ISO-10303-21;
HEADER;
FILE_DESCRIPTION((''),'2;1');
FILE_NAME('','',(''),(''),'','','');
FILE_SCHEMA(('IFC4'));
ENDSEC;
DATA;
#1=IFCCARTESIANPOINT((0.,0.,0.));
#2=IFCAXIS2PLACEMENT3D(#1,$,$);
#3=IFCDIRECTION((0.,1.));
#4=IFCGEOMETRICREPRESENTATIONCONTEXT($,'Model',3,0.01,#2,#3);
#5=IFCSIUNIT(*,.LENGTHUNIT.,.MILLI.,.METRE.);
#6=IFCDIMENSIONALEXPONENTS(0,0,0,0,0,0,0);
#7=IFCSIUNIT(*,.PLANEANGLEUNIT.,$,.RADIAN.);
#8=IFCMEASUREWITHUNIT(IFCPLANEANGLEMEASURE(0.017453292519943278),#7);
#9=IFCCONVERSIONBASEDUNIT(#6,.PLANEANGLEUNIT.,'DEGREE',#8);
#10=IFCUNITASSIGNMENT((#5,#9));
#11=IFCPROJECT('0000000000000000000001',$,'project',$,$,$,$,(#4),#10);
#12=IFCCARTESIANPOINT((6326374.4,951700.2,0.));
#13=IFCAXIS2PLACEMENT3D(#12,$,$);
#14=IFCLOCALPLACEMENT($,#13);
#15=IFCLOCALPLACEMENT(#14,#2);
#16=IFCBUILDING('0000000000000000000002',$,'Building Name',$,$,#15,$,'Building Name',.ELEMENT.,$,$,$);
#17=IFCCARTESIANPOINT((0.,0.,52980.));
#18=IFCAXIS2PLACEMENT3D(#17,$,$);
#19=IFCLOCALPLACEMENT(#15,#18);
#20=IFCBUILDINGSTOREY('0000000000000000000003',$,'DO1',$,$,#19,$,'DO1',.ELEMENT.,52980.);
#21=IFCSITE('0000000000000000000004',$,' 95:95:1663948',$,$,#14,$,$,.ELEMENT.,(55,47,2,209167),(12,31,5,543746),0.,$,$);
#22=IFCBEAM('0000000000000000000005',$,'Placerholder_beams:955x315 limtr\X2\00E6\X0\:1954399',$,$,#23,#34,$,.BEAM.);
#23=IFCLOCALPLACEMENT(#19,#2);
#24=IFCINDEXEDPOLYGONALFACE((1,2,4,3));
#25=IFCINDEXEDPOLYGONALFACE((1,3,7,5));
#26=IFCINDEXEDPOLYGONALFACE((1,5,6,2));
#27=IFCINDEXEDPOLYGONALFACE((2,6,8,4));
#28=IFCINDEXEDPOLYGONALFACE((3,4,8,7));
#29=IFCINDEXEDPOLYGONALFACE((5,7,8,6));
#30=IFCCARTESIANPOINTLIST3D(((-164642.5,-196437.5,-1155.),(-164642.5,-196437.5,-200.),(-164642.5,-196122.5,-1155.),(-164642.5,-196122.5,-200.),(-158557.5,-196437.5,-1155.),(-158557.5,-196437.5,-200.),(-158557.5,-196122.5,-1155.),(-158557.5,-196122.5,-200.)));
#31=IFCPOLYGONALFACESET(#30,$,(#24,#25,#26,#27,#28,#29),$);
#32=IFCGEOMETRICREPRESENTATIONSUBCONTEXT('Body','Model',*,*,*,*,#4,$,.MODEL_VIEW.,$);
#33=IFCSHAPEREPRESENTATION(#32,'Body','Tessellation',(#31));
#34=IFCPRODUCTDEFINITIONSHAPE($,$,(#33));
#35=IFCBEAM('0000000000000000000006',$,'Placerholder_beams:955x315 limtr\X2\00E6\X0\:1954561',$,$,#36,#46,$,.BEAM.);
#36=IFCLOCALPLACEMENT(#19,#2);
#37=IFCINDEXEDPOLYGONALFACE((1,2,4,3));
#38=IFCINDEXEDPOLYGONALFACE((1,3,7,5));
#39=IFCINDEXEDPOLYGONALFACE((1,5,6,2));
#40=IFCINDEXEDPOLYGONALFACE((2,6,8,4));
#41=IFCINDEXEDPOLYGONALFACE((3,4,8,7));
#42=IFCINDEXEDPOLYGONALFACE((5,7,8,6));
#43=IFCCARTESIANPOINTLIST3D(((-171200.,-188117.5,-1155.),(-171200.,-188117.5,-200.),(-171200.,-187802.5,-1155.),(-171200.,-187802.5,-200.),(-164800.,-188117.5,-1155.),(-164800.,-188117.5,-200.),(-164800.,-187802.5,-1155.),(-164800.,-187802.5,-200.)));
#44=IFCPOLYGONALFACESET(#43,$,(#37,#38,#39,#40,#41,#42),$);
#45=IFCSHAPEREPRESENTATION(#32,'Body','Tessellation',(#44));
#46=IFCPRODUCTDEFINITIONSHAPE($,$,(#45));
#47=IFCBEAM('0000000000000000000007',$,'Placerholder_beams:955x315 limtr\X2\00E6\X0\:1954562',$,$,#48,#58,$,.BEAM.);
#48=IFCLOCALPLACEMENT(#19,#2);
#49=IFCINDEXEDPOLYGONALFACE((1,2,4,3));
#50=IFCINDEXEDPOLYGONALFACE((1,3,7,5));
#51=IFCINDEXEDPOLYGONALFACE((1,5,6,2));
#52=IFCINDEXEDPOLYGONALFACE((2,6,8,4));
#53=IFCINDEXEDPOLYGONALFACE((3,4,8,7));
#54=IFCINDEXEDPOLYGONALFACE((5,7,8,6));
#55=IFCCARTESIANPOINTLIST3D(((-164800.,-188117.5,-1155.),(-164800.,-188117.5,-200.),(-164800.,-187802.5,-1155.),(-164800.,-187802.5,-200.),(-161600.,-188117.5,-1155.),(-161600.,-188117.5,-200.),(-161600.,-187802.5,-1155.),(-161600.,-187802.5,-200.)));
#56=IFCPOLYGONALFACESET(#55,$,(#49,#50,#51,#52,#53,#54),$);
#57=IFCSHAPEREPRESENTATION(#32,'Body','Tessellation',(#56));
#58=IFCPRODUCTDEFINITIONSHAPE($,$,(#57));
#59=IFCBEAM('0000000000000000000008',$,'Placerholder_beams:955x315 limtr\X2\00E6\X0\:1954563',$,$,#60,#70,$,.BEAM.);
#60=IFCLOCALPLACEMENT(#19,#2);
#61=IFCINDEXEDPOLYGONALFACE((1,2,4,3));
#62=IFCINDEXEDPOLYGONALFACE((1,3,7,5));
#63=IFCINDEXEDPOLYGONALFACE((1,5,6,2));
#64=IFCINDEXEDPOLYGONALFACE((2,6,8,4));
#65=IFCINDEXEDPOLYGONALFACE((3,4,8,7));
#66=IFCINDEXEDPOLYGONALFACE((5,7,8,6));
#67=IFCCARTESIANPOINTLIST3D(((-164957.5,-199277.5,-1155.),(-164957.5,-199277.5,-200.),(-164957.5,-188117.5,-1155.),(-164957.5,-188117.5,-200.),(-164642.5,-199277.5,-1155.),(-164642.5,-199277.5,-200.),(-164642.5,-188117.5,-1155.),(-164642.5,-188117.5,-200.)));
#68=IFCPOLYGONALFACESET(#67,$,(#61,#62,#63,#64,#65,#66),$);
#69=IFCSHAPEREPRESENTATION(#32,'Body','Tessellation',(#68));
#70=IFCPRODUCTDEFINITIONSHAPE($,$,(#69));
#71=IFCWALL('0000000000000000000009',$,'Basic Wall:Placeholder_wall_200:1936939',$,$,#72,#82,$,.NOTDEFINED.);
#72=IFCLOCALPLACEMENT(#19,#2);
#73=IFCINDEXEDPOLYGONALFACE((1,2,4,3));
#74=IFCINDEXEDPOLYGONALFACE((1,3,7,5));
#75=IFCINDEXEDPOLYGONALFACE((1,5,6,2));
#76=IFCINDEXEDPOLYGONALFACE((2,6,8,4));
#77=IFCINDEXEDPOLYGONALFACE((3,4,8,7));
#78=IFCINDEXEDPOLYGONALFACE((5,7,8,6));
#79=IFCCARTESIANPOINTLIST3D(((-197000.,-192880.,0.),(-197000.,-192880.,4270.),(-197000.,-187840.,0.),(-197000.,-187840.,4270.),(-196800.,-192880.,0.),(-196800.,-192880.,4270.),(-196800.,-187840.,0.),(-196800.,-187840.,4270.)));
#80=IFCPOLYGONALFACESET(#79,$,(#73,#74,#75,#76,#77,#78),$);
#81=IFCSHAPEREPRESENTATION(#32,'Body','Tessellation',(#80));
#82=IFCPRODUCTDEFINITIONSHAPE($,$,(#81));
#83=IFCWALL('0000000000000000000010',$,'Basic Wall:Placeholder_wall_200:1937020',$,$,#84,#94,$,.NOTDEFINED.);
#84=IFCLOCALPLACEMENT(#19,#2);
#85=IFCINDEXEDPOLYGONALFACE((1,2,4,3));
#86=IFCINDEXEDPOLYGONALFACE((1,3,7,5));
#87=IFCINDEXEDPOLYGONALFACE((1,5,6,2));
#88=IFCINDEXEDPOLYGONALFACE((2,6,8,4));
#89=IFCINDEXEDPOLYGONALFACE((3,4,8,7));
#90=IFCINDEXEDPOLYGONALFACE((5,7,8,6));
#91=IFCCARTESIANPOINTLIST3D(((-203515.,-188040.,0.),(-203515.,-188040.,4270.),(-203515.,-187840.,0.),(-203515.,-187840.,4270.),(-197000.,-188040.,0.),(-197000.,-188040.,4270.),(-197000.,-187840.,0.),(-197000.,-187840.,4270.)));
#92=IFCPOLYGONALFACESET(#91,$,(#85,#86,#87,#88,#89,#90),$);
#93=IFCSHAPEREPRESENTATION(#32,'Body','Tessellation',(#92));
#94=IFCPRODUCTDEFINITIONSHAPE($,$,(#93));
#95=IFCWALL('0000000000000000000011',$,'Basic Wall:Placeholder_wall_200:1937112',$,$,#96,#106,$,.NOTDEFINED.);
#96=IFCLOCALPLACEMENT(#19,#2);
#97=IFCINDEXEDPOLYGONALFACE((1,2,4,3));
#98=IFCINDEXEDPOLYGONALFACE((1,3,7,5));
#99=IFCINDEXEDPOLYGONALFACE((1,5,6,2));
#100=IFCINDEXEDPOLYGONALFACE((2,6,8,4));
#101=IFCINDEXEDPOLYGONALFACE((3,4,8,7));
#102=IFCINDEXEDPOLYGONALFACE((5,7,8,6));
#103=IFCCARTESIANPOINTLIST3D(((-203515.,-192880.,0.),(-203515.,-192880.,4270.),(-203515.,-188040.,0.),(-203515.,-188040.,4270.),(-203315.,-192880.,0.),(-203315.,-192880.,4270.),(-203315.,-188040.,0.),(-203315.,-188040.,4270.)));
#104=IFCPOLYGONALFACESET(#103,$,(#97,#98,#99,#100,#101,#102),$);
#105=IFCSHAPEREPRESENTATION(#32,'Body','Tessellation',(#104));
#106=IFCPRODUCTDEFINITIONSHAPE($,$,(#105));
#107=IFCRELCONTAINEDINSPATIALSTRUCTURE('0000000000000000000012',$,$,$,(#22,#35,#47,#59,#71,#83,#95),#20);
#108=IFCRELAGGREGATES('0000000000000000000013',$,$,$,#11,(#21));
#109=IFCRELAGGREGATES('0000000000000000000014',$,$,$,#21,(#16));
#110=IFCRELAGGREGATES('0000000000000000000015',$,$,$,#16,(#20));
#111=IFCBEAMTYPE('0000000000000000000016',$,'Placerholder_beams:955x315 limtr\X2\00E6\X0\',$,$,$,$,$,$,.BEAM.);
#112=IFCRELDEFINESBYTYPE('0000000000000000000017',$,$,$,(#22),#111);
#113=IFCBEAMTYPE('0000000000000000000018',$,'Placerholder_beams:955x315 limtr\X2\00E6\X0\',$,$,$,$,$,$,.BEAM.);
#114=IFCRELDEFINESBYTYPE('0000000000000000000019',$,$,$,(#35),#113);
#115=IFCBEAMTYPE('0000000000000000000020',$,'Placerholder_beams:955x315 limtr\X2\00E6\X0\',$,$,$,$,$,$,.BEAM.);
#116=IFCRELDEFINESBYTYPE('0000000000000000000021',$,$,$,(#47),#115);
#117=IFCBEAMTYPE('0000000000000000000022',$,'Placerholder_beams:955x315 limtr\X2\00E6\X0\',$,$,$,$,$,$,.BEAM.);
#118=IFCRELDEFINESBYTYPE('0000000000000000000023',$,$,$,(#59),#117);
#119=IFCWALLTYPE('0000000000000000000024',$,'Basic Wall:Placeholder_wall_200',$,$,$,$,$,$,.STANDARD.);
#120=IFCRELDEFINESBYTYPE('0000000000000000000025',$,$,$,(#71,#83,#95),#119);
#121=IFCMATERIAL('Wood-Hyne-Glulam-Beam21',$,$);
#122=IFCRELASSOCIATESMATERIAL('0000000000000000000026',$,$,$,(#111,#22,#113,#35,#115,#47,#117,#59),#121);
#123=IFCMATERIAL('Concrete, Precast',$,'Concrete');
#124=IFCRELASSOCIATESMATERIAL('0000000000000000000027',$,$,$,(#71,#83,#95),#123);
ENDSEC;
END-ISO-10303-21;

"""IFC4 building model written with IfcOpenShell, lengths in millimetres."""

from ifc_helpers import new_model, entity, si_unit, converted_unit, direction, frame, origin, place, context, subcontext, project, spatial, indexed_curve, outline, extrude, source, transform, mapped, material, type_object, type_shapes, element, save


model = new_model("IFC4")

# Units and contexts
model_context = context("Model", 3, precision=0.01, world=origin(), true_north=direction((0.0, 1.0)))
body_context = subcontext(model_context, "Body", "Model", "MODEL_VIEW")
ifc_project = project(units=[si_unit("LENGTHUNIT", "METRE", prefix="MILLI"), converted_unit("PLANEANGLEUNIT", "DEGREE", entity("IfcPlaneAngleMeasure", 0.017453292519943278), si_unit("PLANEANGLEUNIT", "RADIAN"), dimensions=[0, 0, 0, 0, 0, 0, 0])], contexts=[model_context])

# Site, building, storey
site_placement = place(None, frame((6326374.4, 951700.2, 0.0)))
site = spatial("IfcSite", under=ifc_project, at=site_placement, Name=" 95:95:1663948", CompositionType="ELEMENT", RefLatitude=(55, 47, 2, 209167), RefLongitude=(12, 31, 5, 543746), RefElevation=0.0)
building_placement = place(site_placement, origin())
building = spatial("IfcBuilding", under=site, at=building_placement, Name="Building Name", LongName="Building Name", CompositionType="ELEMENT")
storey_placement = place(building_placement, frame((0.0, 0.0, 52980.0)))
storey = spatial("IfcBuildingStorey", under=building, at=storey_placement, Name="DO1", LongName="DO1", CompositionType="ELEMENT", Elevation=52980.0)

# Beams
ifc_material_1 = material(Name="Wood-Hyne-Glulam-Beam21")
beam_type_1 = type_object("IfcBeamType", Name="Placerholder_beams:955x315 limtræ", PredefinedType="BEAM", material=ifc_material_1)
shared_shape_1 = source(origin(), body_context, "Body", "SweptSolid", [
    extrude(outline(indexed_curve([(-3042.5, -157.5), (3042.5, -157.5), (3042.5, 157.5), (-3042.5, 157.5), (-3042.5, -157.5)], self_intersect=False)), frame((0.0, 0.0, -477.5)), (0.0, 0.0, 1.0), 955.0),
])
type_shapes(beam_type_1, [shared_shape_1])
beam_1_placement = place(storey_placement, frame((-161600.0, -196280.0, -677.5)))
element("IfcBeam", 1, at=beam_1_placement, inside=storey, type_object=beam_type_1, material=ifc_material_1, Name="Placerholder_beams:955x315 limtræ:1954399", PredefinedType="BEAM", context=body_context, shape_type="MappedRepresentation", body=[
    mapped(shared_shape_1, transform((0.0, 0.0, 0.0), scale=1.0)),
])
beam_type_2 = type_object("IfcBeamType", Name="Placerholder_beams:955x315 limtræ", PredefinedType="BEAM", material=ifc_material_1)
shared_shape_2 = source(origin(), body_context, "Body", "SweptSolid", [
    extrude(outline(indexed_curve([(-3200.0, -157.5), (3200.0, -157.5), (3200.0, 157.5), (-3200.0, 157.5), (-3200.0, -157.5)], self_intersect=False)), frame((0.0, 0.0, -477.5)), (0.0, 0.0, 1.0), 955.0),
])
type_shapes(beam_type_2, [shared_shape_2])
beam_2_placement = place(storey_placement, frame((-168000.0, -187960.0, -677.5)))
element("IfcBeam", 2, at=beam_2_placement, inside=storey, type_object=beam_type_2, material=ifc_material_1, Name="Placerholder_beams:955x315 limtræ:1954561", PredefinedType="BEAM", context=body_context, shape_type="MappedRepresentation", body=[
    mapped(shared_shape_2, transform((0.0, 0.0, 0.0), scale=1.0)),
])
beam_type_3 = type_object("IfcBeamType", Name="Placerholder_beams:955x315 limtræ", PredefinedType="BEAM", material=ifc_material_1)
shared_shape_3 = source(origin(), body_context, "Body", "SweptSolid", [
    extrude(outline(indexed_curve([(-1600.0, -157.5), (1600.0, -157.5), (1600.0, 157.5), (-1600.0, 157.5), (-1600.0, -157.5)], self_intersect=False)), frame((-50.0, 0.0, -477.5)), (0.0, 0.0, 1.0), 955.0),
])
type_shapes(beam_type_3, [shared_shape_3])
beam_3_placement = place(storey_placement, frame((-163150.0, -187960.0, -677.5)))
element("IfcBeam", 3, at=beam_3_placement, inside=storey, type_object=beam_type_3, material=ifc_material_1, Name="Placerholder_beams:955x315 limtræ:1954562", PredefinedType="BEAM", context=body_context, shape_type="MappedRepresentation", body=[
    mapped(shared_shape_3, transform((0.0, 0.0, 0.0), scale=1.0)),
])
beam_type_4 = type_object("IfcBeamType", Name="Placerholder_beams:955x315 limtræ", PredefinedType="BEAM", material=ifc_material_1)
shared_shape_4 = source(origin(), body_context, "Body", "SweptSolid", [
    extrude(outline(indexed_curve([(-5580.0, -157.5), (5580.0, -157.5), (5580.0, 157.5), (-5580.0, 157.5), (-5580.0, -157.5)], self_intersect=False)), frame((0.0, 0.0, -477.5)), (0.0, 0.0, 1.0), 955.0),
])
type_shapes(beam_type_4, [shared_shape_4])
beam_4_placement = place(storey_placement, frame((-164800.0, -193697.5, -677.5), z_axis=(0.0, 0.0, 1.0), x_axis=(0.0, -1.0, 0.0)))
element("IfcBeam", 4, at=beam_4_placement, inside=storey, type_object=beam_type_4, material=ifc_material_1, Name="Placerholder_beams:955x315 limtræ:1954563", PredefinedType="BEAM", context=body_context, shape_type="MappedRepresentation", body=[
    mapped(shared_shape_4, transform((0.0, 0.0, 0.0), scale=1.0)),
])

# Walls
ifc_material_2 = material(Name="Concrete, Precast", Category="Concrete")
wall_type = type_object("IfcWallType", Name="Basic Wall:Placeholder_wall_200", PredefinedType="STANDARD")
wall_1_placement = place(storey_placement, frame((-196900.0, -192880.0, 0.0), z_axis=(0.0, 0.0, 1.0), x_axis=(0.0, 1.0, 0.0)))
element("IfcWall", 5, at=wall_1_placement, inside=storey, type_object=wall_type, material=ifc_material_2, Name="Basic Wall:Placeholder_wall_200:1936939", PredefinedType="NOTDEFINED", context=body_context, shape_type="SweptSolid", body=[
    extrude(outline(indexed_curve([(5040.0, 100.0), (0.0, 100.0), (0.0, -100.0), (5040.0, -100.0), (5040.0, 100.0)], self_intersect=False)), origin(), (0.0, 0.0, 1.0), 4270.0),
])
wall_2_placement = place(storey_placement, frame((-197000.0, -187940.0, 0.0), z_axis=(0.0, 0.0, 1.0), x_axis=(-1.0, 0.0, 0.0)))
element("IfcWall", 6, at=wall_2_placement, inside=storey, type_object=wall_type, material=ifc_material_2, Name="Basic Wall:Placeholder_wall_200:1937020", PredefinedType="NOTDEFINED", context=body_context, shape_type="SweptSolid", body=[
    extrude(outline(indexed_curve([(6515.0, 100.0), (0.0, 100.0), (0.0, -100.0), (6515.0, -100.0), (6515.0, 100.0)], self_intersect=False)), origin(), (0.0, 0.0, 1.0), 4270.0),
])
wall_3_placement = place(storey_placement, frame((-203415.0, -188040.0, 0.0), z_axis=(0.0, 0.0, 1.0), x_axis=(0.0, -1.0, 0.0)))
element("IfcWall", 7, at=wall_3_placement, inside=storey, type_object=wall_type, material=ifc_material_2, Name="Basic Wall:Placeholder_wall_200:1937112", PredefinedType="NOTDEFINED", context=body_context, shape_type="SweptSolid", body=[
    extrude(outline(indexed_curve([(4840.0, 100.0), (0.0, 100.0), (0.0, -100.0), (4840.0, -100.0), (4840.0, 100.0)], self_intersect=False)), origin(), (0.0, 0.0, 1.0), 4270.0),
])

save(model, "model.ifc")
